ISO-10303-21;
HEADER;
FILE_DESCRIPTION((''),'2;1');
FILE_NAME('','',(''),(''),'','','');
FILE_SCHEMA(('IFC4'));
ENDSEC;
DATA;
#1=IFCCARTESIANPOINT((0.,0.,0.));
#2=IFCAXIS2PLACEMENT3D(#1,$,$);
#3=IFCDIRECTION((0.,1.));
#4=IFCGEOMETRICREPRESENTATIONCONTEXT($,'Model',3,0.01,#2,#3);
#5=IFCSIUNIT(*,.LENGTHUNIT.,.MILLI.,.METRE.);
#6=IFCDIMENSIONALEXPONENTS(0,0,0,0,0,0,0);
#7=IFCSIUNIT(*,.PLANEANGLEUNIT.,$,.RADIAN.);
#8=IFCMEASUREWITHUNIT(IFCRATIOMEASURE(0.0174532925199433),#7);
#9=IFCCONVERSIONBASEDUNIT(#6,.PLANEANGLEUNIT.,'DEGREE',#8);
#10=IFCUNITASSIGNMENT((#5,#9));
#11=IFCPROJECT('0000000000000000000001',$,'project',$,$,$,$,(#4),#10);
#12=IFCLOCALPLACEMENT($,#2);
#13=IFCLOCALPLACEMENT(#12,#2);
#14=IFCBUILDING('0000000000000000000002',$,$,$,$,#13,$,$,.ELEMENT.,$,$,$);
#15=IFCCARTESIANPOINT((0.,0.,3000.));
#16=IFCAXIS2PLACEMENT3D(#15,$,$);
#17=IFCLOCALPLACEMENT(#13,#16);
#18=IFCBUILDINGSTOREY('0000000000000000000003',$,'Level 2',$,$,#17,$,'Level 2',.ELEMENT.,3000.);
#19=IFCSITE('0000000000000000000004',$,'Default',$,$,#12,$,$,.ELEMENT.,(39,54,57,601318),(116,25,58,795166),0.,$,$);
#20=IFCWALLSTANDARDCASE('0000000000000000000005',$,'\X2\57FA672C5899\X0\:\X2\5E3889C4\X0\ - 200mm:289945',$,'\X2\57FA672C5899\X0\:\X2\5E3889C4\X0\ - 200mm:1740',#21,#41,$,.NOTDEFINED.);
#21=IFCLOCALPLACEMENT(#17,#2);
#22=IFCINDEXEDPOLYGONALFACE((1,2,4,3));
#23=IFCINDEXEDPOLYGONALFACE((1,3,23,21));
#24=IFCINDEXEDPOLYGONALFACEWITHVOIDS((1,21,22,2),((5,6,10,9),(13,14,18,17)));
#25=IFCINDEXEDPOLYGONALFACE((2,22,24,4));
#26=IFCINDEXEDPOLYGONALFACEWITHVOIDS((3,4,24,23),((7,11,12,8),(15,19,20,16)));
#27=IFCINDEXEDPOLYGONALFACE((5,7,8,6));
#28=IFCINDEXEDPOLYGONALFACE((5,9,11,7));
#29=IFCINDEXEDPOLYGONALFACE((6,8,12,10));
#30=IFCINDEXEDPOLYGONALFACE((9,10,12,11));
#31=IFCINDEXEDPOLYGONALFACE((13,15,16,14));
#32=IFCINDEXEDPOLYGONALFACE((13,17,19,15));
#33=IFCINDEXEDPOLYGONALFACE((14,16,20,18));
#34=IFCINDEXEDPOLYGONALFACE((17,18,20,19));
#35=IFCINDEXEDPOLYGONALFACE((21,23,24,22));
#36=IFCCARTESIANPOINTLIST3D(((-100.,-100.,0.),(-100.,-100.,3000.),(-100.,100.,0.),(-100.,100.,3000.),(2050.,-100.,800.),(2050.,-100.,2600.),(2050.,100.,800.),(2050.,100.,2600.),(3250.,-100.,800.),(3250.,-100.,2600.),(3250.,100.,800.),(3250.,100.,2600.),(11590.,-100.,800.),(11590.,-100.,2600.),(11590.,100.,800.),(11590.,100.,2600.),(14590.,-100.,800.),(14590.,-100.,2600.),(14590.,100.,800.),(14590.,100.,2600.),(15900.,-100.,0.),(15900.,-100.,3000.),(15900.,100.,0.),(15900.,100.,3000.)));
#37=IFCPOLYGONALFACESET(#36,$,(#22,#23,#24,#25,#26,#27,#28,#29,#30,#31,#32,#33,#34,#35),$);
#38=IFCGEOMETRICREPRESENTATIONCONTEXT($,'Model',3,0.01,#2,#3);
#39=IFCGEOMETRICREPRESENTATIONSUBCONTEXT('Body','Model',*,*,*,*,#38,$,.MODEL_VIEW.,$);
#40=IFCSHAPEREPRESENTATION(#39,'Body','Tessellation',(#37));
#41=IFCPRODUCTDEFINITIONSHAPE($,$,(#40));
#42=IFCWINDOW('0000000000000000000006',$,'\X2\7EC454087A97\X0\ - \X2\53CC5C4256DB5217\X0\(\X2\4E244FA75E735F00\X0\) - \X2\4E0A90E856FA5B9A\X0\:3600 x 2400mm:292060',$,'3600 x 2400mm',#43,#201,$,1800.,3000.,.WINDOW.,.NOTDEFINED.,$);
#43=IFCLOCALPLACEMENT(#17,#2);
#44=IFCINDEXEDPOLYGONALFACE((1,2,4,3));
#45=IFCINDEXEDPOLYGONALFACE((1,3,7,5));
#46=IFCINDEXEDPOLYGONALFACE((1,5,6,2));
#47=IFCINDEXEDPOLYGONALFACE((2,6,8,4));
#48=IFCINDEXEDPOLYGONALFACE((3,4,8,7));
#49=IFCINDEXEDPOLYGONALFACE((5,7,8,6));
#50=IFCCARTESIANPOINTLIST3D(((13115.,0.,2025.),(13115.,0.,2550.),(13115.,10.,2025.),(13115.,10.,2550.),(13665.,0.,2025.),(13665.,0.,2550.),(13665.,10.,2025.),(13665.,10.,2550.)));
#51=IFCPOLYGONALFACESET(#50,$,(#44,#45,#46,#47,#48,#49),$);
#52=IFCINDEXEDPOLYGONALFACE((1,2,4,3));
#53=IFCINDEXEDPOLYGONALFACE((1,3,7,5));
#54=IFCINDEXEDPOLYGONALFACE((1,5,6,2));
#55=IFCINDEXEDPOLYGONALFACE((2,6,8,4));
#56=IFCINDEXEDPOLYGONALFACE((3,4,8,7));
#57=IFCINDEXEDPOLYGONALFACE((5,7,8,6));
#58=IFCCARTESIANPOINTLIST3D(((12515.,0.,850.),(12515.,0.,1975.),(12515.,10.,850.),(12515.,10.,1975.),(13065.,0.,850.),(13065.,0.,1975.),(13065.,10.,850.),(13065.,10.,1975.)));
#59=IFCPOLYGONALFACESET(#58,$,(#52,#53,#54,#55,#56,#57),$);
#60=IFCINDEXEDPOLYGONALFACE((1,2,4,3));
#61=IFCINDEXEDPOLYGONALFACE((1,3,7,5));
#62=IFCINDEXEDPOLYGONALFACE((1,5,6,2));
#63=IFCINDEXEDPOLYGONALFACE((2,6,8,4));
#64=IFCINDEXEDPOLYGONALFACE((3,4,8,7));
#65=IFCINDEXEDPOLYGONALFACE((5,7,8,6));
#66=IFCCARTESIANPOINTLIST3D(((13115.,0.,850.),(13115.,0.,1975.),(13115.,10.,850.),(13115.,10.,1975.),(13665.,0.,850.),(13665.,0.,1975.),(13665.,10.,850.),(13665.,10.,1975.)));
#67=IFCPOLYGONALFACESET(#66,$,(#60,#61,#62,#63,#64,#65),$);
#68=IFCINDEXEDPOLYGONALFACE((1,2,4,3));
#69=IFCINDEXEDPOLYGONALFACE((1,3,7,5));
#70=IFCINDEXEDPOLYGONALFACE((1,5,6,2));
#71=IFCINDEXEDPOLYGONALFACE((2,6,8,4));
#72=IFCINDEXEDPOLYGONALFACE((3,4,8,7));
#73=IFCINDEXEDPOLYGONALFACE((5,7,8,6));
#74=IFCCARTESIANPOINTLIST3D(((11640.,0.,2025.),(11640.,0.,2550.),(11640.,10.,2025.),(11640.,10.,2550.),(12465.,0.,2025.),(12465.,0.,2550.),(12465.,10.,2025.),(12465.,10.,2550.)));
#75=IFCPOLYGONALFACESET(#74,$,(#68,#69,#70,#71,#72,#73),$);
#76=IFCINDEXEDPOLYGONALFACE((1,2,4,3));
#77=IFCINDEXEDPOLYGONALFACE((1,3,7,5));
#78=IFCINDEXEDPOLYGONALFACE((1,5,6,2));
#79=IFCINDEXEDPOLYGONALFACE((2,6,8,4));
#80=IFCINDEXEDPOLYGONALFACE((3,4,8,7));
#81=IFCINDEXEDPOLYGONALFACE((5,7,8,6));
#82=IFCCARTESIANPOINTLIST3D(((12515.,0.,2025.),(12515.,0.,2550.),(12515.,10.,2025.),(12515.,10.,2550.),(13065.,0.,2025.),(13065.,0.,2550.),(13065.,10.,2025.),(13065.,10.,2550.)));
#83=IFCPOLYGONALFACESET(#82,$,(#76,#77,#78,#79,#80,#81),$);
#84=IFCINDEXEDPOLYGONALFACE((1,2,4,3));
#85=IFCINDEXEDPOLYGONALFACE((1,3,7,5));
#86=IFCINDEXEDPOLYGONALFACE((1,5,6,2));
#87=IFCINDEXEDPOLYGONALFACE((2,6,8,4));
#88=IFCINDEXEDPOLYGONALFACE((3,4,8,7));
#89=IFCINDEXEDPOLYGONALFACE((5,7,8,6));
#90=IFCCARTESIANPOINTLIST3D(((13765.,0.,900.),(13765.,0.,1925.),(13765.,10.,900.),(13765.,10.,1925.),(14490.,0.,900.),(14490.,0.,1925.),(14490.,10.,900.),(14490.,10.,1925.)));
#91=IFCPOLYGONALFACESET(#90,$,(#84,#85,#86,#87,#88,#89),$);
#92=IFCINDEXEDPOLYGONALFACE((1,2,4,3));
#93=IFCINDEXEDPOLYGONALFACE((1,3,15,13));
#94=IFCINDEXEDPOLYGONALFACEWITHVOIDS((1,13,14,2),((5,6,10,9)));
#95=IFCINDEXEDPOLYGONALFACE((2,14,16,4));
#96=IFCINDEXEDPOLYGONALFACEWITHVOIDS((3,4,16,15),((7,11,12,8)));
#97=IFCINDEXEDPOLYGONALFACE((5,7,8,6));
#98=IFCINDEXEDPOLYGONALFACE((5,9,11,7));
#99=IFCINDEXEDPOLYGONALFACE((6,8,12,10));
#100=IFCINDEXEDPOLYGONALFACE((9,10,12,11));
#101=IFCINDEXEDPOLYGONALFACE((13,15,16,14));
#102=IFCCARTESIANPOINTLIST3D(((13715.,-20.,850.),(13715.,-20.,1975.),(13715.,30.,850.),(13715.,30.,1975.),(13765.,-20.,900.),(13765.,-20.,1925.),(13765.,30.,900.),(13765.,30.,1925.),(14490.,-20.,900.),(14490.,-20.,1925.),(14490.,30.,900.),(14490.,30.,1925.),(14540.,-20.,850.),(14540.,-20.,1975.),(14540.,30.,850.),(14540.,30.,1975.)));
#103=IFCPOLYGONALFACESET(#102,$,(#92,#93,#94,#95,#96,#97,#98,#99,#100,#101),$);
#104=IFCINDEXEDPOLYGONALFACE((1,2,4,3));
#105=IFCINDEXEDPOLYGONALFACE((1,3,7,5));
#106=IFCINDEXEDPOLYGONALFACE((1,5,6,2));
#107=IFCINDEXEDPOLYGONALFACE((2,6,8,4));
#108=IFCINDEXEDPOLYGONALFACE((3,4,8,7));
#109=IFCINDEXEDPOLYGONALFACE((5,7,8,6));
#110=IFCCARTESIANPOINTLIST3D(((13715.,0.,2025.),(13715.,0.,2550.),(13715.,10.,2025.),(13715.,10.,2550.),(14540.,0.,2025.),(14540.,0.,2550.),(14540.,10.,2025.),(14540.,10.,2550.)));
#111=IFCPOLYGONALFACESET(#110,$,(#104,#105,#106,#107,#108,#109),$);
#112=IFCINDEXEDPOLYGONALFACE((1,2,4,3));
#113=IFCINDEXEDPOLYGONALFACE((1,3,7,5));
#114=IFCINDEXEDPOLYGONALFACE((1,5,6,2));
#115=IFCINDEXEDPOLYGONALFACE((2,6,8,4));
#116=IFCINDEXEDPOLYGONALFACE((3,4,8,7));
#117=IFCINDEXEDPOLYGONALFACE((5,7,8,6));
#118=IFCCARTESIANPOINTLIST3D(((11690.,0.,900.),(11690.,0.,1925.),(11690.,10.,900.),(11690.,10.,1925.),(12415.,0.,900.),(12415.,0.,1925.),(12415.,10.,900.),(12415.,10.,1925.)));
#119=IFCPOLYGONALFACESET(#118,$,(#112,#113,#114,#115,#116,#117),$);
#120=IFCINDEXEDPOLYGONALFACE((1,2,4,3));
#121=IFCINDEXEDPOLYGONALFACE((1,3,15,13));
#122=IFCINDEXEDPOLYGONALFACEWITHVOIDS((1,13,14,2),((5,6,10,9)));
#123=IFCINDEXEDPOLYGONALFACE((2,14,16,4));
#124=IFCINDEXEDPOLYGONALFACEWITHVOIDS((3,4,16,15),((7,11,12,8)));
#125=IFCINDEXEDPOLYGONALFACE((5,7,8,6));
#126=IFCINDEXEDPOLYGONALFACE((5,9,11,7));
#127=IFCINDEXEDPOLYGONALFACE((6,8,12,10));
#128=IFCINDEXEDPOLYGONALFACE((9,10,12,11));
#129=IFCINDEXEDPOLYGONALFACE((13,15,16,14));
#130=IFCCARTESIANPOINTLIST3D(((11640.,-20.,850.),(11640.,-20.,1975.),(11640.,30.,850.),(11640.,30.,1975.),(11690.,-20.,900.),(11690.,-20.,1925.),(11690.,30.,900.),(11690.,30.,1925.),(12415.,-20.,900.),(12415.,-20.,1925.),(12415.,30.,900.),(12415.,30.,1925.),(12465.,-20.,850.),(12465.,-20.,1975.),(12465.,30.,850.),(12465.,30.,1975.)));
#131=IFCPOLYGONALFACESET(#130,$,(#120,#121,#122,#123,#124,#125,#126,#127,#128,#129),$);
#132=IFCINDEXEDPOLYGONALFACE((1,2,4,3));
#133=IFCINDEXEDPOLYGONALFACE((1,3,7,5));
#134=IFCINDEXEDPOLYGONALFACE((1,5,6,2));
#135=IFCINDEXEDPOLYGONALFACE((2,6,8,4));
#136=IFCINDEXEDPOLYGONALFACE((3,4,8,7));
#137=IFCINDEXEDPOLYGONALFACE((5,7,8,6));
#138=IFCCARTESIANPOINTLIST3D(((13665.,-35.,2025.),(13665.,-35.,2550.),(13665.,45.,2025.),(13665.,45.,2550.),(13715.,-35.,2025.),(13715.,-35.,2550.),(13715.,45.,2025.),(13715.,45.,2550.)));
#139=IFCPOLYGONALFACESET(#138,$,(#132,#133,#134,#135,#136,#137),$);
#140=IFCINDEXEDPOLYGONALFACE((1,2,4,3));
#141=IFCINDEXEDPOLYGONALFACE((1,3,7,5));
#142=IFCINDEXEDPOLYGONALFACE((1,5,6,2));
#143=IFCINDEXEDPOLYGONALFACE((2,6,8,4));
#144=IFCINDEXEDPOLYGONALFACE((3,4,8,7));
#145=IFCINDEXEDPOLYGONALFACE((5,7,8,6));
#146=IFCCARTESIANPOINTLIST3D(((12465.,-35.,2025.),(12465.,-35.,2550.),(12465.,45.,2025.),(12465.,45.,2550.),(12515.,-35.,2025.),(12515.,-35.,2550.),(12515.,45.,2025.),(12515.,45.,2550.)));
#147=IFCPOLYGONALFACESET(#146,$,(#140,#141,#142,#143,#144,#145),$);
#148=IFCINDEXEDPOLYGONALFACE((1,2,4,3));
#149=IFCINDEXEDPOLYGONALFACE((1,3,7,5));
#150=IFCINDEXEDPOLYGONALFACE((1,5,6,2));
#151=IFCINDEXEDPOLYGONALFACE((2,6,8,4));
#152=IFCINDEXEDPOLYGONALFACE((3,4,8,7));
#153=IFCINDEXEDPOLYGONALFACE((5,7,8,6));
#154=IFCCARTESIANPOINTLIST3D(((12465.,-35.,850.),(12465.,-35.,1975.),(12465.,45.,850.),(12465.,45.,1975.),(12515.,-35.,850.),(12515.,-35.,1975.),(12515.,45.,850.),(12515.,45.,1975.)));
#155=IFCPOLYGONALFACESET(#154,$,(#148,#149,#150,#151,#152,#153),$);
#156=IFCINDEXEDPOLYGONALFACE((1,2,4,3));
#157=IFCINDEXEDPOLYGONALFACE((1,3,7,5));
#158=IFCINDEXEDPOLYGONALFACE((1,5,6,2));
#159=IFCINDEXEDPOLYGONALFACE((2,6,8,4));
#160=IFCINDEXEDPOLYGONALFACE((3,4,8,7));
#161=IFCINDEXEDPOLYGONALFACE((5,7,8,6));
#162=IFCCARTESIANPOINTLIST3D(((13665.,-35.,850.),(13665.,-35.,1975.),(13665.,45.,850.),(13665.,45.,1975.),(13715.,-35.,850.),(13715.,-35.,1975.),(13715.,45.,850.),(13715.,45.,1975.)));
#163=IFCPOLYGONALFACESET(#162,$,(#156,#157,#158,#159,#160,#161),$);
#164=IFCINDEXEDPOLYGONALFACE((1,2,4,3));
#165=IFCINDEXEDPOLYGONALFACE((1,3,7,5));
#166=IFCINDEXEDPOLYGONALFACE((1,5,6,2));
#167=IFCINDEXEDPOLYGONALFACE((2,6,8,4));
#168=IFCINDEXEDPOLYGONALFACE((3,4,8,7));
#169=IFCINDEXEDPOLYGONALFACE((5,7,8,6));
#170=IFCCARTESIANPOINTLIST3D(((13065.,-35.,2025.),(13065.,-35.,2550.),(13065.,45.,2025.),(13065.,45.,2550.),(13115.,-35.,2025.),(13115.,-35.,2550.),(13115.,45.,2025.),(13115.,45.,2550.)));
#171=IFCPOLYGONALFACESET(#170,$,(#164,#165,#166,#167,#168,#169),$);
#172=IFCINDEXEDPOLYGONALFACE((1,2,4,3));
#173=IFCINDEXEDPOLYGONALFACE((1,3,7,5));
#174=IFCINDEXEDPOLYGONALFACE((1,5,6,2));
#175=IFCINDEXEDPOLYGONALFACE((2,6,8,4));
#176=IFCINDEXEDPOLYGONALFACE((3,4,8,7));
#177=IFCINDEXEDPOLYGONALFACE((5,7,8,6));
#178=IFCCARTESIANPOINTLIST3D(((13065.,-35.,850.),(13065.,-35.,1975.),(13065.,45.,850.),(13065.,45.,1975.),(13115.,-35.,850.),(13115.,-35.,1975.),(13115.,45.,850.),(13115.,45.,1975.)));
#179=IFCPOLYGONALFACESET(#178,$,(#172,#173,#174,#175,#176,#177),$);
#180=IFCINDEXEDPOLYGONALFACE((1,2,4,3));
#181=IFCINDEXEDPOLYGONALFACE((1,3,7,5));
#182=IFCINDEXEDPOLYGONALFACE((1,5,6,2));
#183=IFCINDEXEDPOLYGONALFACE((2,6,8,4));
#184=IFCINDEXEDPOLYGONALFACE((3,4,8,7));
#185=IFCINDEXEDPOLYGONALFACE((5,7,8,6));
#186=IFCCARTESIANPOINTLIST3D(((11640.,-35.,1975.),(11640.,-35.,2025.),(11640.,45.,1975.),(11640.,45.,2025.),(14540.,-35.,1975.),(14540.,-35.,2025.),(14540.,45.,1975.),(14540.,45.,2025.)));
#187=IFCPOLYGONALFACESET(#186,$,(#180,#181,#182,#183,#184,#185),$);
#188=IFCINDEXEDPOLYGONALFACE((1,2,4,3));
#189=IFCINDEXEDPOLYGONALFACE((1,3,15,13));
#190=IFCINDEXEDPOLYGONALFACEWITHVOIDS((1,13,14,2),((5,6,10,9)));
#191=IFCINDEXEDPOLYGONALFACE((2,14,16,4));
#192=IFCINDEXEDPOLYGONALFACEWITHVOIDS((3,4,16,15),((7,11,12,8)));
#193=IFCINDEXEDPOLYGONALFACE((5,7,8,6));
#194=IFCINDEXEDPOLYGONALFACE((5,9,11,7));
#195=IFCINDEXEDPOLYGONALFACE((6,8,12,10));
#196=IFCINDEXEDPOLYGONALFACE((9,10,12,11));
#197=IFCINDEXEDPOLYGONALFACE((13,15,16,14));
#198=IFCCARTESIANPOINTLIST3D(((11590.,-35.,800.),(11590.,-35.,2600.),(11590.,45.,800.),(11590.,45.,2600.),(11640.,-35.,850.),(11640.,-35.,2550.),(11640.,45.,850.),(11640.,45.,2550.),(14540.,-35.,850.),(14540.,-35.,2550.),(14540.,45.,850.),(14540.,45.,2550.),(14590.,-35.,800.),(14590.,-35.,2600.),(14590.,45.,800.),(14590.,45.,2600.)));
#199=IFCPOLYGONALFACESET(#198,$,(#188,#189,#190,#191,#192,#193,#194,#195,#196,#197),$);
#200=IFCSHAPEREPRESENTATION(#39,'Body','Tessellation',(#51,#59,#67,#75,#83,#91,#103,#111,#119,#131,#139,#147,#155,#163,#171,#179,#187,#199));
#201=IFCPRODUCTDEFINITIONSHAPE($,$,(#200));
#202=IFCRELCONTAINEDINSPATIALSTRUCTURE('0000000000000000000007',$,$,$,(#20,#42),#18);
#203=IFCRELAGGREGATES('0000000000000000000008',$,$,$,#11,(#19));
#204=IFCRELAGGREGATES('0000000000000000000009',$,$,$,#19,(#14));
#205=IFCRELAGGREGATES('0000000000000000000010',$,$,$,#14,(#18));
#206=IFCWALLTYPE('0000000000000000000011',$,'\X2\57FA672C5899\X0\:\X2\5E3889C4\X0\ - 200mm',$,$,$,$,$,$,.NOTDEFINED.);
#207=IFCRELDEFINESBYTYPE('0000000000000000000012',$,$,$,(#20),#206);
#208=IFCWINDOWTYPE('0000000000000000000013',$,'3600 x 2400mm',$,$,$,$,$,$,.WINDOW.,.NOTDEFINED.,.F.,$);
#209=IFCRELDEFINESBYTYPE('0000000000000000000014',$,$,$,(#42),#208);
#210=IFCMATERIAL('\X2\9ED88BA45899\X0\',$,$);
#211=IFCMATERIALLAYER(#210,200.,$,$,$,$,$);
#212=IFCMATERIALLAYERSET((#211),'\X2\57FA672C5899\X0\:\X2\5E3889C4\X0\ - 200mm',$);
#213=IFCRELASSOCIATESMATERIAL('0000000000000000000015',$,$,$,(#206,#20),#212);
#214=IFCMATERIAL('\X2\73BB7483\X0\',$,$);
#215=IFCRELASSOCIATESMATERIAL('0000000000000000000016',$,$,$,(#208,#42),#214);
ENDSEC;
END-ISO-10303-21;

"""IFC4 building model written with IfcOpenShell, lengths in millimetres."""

from ifc_helpers import new_model, entity, si_unit, converted_unit, direction, frame, frame_2d, origin, origin_2d_with_axis, place, context, subcontext, project, spatial, polyline, rectangle, outline, extrude, source, transform, mapped, material, layer, layer_set, layer_usage, type_object, type_shapes, element, fill, save


model = new_model("IFC4")

# Units and contexts
model_context_1 = context("Model", 3, precision=0.01, world=origin(), true_north=direction((0.0, 1.0)))
model_context_2 = context("Model", 3, precision=0.01, world=origin(), true_north=direction((0.0, 1.0)))
body_context = subcontext(model_context_2, "Body", "Model", "MODEL_VIEW")
ifc_project = project(units=[si_unit("LENGTHUNIT", "METRE", prefix="MILLI"), converted_unit("PLANEANGLEUNIT", "DEGREE", entity("IfcRatioMeasure", 0.0174532925199433), si_unit("PLANEANGLEUNIT", "RADIAN"), dimensions=[0, 0, 0, 0, 0, 0, 0])], contexts=[model_context_1])

# Site, building, storey
site_placement = place(None, origin())
site = spatial("IfcSite", under=ifc_project, at=site_placement, Name="Default", CompositionType="ELEMENT", RefLatitude=(39, 54, 57, 601318), RefLongitude=(116, 25, 58, 795166), RefElevation=0.0)
building_placement = place(site_placement, origin())
building = spatial("IfcBuilding", under=site, at=building_placement, CompositionType="ELEMENT")
storey_placement = place(building_placement, frame((0.0, 0.0, 3000.0)))
storey = spatial("IfcBuildingStorey", under=building, at=storey_placement, Name="Level 2", LongName="Level 2", CompositionType="ELEMENT", Elevation=3000.0)

# Shared definitions
ifc_material_1 = material(Name="默认墙")
ifc_layer = layer(ifc_material_1, 200.0)
ifc_layer_set = layer_set([ifc_layer], Name="基本墙:常规 - 200mm")
wall_type = type_object("IfcWallType", Name="基本墙:常规 - 200mm", PredefinedType="NOTDEFINED", material=ifc_layer_set)

# Shared definitions
ifc_material_2 = material(Name="玻璃")

# Wall, openings, window
ifc_layer_usage_1 = layer_usage(ifc_layer_set, "AXIS2", "NEGATIVE", 100.0)
wall_1_placement = place(storey_placement, frame((15900.0, 0.0, 0.0), z_axis=(0.0, 0.0, 1.0), x_axis=(-1.0, 0.0, 0.0)))
wall_1 = element("IfcWallStandardCase", 1, at=wall_1_placement, inside=storey, type_object=wall_type, material=ifc_layer_usage_1, Name="基本墙:常规 - 200mm:289945", ObjectType="基本墙:常规 - 200mm:1740", PredefinedType="NOTDEFINED", context=body_context, shape_type="SweptSolid", body=[
    extrude(rectangle(XDim=16000.0, YDim=200.0, at=frame_2d((8000.0, 0.0), x_axis=(-1.0, 0.0))), origin(), (0.0, 0.0, 1.0), 3000.0),
])
opening_1_placement = place(wall_1_placement, frame((12650.0, -100.0, 800.0)))
element("IfcOpeningElement", 2, at=opening_1_placement, cuts=wall_1, ObjectType="Opening", PredefinedType="OPENING", context=body_context, shape_type="SweptSolid", body=[
    extrude(rectangle(XDim=1800.0, YDim=1200.0, at=frame_2d((900.0, 600.0), x_axis=(1.0, 0.0))), frame((0.0, 0.0, 0.0), z_axis=(0.0, 1.0, 0.0), x_axis=(0.0, 0.0, 1.0)), (0.0, 0.0, 1.0), 200.0),
])
opening_2_placement = place(wall_1_placement, frame((1310.0, -100.0, 800.0)))
opening_2 = element("IfcOpeningElement", 3, at=opening_2_placement, cuts=wall_1, ObjectType="Opening", PredefinedType="OPENING", context=body_context, shape_type="SweptSolid", body=[
    extrude(rectangle(XDim=1800.0, YDim=3000.0, at=frame_2d((900.0, 1500.0), x_axis=(1.0, 0.0))), frame((0.0, 0.0, 0.0), z_axis=(0.0, 1.0, 0.0), x_axis=(0.0, 0.0, 1.0)), (0.0, 0.0, 1.0), 200.0),
])
window_type_1 = type_object("IfcWindowType", Name="3600 x 2400mm", ParameterTakesPrecedence=False, PartitioningType="NOTDEFINED", PredefinedType="WINDOW", material=ifc_material_2)
shared_shape_1 = source(origin(), body_context, "Body", "SweptSolid", [
    extrude(rectangle(XDim=10.0, YDim=550.0, at=origin_2d_with_axis()), frame((1200.0, 95.0, 1225.0), z_axis=(0.0, 0.0, 1.0), x_axis=(0.0, 1.0, 0.0)), (0.0, 0.0, 1.0), 525.0),
    extrude(rectangle(XDim=10.0, YDim=550.0, at=origin_2d_with_axis()), frame((1800.0, 95.0, 50.0), z_axis=(0.0, 0.0, 1.0), x_axis=(0.0, 1.0, 0.0)), (0.0, 0.0, 1.0), 1125.0),
    extrude(rectangle(XDim=10.0, YDim=550.0, at=origin_2d_with_axis()), frame((1200.0, 95.0, 50.0), z_axis=(0.0, 0.0, 1.0), x_axis=(0.0, 1.0, 0.0)), (0.0, 0.0, 1.0), 1125.0),
    extrude(rectangle(XDim=10.0, YDim=825.0, at=origin_2d_with_axis()), frame((2537.5, 95.0, 1225.0), z_axis=(0.0, 0.0, 1.0), x_axis=(0.0, 1.0, 0.0)), (0.0, 0.0, 1.0), 525.0),
    extrude(rectangle(XDim=10.0, YDim=550.0, at=origin_2d_with_axis()), frame((1800.0, 95.0, 1225.0), z_axis=(0.0, 0.0, 1.0), x_axis=(0.0, 1.0, 0.0)), (0.0, 0.0, 1.0), 525.0),
    extrude(rectangle(XDim=10.0, YDim=725.0, at=origin_2d_with_axis()), frame((462.5, 95.0, 100.0), z_axis=(0.0, 0.0, 1.0), x_axis=(0.0, 1.0, 0.0)), (0.0, 0.0, 1.0), 1025.0),
    extrude(outline(polyline([(-562.5, -412.5), (562.5, -412.5), (562.5, 412.5), (-562.5, 412.5), (-562.5, -412.5)]), holes=[polyline([(512.5, -362.5), (-512.5, -362.5), (-512.5, 362.5), (512.5, 362.5), (512.5, -362.5)])]), frame((462.5, 70.0, 612.5), z_axis=(0.0, 1.0, 0.0), x_axis=(0.0, 0.0, -1.0)), (0.0, 0.0, 1.0), 50.0),
    extrude(rectangle(XDim=10.0, YDim=825.0, at=origin_2d_with_axis()), frame((462.5, 95.0, 1225.0), z_axis=(0.0, 0.0, 1.0), x_axis=(0.0, 1.0, 0.0)), (0.0, 0.0, 1.0), 525.0),
    extrude(rectangle(XDim=10.0, YDim=725.0, at=origin_2d_with_axis()), frame((2537.5, 95.0, 100.0), z_axis=(0.0, 0.0, 1.0), x_axis=(0.0, 1.0, 0.0)), (0.0, 0.0, 1.0), 1025.0),
    extrude(outline(polyline([(-562.5, -412.5), (562.5, -412.5), (562.5, 412.5), (-562.5, 412.5), (-562.5, -412.5)]), holes=[polyline([(512.5, -362.5), (-512.5, -362.5), (-512.5, 362.5), (512.5, 362.5), (512.5, -362.5)])]), frame((2537.5, 70.0, 612.5), z_axis=(0.0, 1.0, 0.0), x_axis=(0.0, 0.0, -1.0)), (0.0, 0.0, 1.0), 50.0),
    extrude(rectangle(XDim=80.0, YDim=50.0, at=origin_2d_with_axis()), frame((900.0, 95.0, 1225.0), z_axis=(0.0, 0.0, 1.0), x_axis=(0.0, -1.0, 0.0)), (0.0, 0.0, 1.0), 525.0),
    extrude(rectangle(XDim=80.0, YDim=50.0, at=origin_2d_with_axis()), frame((2100.0, 95.0, 1225.0), z_axis=(0.0, 0.0, 1.0), x_axis=(0.0, -1.0, 0.0)), (0.0, 0.0, 1.0), 525.0),
    extrude(rectangle(XDim=80.0, YDim=50.0, at=origin_2d_with_axis()), frame((2100.0, 95.0, 50.0), z_axis=(0.0, 0.0, 1.0), x_axis=(0.0, -1.0, 0.0)), (0.0, 0.0, 1.0), 1125.0),
    extrude(rectangle(XDim=80.0, YDim=50.0, at=origin_2d_with_axis()), frame((900.0, 95.0, 50.0), z_axis=(0.0, 0.0, 1.0), x_axis=(0.0, -1.0, 0.0)), (0.0, 0.0, 1.0), 1125.0),
    extrude(rectangle(XDim=80.0, YDim=50.0, at=origin_2d_with_axis()), frame((1500.0, 95.0, 1225.0), z_axis=(0.0, 0.0, 1.0), x_axis=(0.0, -1.0, 0.0)), (0.0, 0.0, 1.0), 525.0),
    extrude(rectangle(XDim=80.0, YDim=50.0, at=origin_2d_with_axis()), frame((1500.0, 95.0, 50.0), z_axis=(0.0, 0.0, 1.0), x_axis=(0.0, -1.0, 0.0)), (0.0, 0.0, 1.0), 1125.0),
    extrude(rectangle(XDim=80.0, YDim=2900.0, at=origin_2d_with_axis()), frame((1500.0, 95.0, 1175.0), z_axis=(0.0, 0.0, 1.0), x_axis=(0.0, -1.0, 0.0)), (0.0, 0.0, 1.0), 50.0),
    extrude(outline(polyline([(-1500.0, -900.0), (1500.0, -900.0), (1500.0, 900.0), (-1500.0, 900.0), (-1500.0, -900.0)]), holes=[polyline([(1450.0, -850.0), (-1450.0, -850.0), (-1450.0, 850.0), (1450.0, 850.0), (1450.0, -850.0)])]), frame((1500.0, 55.0, 900.0), z_axis=(0.0, 1.0, 0.0), x_axis=(1.0, 0.0, 0.0)), (0.0, 0.0, 1.0), 80.0),
])
type_shapes(window_type_1, [shared_shape_1])
window_1_placement = place(opening_2_placement, origin())
window_1 = element("IfcWindow", 4, at=window_1_placement, inside=storey, type_object=window_type_1, material=ifc_material_2, Name="组合窗 - 双层四列(两侧平开) - 上部固定:3600 x 2400mm:292060", ObjectType="3600 x 2400mm", OverallHeight=1800.0, OverallWidth=3000.0, PartitioningType="NOTDEFINED", PredefinedType="WINDOW", context=body_context, shape_type="MappedRepresentation", body=[
    mapped(shared_shape_1, transform((0.0, 0.0, 0.0), scale=1.0)),
])
fill(opening_2, window_1)

save(model, "model.ifc")
